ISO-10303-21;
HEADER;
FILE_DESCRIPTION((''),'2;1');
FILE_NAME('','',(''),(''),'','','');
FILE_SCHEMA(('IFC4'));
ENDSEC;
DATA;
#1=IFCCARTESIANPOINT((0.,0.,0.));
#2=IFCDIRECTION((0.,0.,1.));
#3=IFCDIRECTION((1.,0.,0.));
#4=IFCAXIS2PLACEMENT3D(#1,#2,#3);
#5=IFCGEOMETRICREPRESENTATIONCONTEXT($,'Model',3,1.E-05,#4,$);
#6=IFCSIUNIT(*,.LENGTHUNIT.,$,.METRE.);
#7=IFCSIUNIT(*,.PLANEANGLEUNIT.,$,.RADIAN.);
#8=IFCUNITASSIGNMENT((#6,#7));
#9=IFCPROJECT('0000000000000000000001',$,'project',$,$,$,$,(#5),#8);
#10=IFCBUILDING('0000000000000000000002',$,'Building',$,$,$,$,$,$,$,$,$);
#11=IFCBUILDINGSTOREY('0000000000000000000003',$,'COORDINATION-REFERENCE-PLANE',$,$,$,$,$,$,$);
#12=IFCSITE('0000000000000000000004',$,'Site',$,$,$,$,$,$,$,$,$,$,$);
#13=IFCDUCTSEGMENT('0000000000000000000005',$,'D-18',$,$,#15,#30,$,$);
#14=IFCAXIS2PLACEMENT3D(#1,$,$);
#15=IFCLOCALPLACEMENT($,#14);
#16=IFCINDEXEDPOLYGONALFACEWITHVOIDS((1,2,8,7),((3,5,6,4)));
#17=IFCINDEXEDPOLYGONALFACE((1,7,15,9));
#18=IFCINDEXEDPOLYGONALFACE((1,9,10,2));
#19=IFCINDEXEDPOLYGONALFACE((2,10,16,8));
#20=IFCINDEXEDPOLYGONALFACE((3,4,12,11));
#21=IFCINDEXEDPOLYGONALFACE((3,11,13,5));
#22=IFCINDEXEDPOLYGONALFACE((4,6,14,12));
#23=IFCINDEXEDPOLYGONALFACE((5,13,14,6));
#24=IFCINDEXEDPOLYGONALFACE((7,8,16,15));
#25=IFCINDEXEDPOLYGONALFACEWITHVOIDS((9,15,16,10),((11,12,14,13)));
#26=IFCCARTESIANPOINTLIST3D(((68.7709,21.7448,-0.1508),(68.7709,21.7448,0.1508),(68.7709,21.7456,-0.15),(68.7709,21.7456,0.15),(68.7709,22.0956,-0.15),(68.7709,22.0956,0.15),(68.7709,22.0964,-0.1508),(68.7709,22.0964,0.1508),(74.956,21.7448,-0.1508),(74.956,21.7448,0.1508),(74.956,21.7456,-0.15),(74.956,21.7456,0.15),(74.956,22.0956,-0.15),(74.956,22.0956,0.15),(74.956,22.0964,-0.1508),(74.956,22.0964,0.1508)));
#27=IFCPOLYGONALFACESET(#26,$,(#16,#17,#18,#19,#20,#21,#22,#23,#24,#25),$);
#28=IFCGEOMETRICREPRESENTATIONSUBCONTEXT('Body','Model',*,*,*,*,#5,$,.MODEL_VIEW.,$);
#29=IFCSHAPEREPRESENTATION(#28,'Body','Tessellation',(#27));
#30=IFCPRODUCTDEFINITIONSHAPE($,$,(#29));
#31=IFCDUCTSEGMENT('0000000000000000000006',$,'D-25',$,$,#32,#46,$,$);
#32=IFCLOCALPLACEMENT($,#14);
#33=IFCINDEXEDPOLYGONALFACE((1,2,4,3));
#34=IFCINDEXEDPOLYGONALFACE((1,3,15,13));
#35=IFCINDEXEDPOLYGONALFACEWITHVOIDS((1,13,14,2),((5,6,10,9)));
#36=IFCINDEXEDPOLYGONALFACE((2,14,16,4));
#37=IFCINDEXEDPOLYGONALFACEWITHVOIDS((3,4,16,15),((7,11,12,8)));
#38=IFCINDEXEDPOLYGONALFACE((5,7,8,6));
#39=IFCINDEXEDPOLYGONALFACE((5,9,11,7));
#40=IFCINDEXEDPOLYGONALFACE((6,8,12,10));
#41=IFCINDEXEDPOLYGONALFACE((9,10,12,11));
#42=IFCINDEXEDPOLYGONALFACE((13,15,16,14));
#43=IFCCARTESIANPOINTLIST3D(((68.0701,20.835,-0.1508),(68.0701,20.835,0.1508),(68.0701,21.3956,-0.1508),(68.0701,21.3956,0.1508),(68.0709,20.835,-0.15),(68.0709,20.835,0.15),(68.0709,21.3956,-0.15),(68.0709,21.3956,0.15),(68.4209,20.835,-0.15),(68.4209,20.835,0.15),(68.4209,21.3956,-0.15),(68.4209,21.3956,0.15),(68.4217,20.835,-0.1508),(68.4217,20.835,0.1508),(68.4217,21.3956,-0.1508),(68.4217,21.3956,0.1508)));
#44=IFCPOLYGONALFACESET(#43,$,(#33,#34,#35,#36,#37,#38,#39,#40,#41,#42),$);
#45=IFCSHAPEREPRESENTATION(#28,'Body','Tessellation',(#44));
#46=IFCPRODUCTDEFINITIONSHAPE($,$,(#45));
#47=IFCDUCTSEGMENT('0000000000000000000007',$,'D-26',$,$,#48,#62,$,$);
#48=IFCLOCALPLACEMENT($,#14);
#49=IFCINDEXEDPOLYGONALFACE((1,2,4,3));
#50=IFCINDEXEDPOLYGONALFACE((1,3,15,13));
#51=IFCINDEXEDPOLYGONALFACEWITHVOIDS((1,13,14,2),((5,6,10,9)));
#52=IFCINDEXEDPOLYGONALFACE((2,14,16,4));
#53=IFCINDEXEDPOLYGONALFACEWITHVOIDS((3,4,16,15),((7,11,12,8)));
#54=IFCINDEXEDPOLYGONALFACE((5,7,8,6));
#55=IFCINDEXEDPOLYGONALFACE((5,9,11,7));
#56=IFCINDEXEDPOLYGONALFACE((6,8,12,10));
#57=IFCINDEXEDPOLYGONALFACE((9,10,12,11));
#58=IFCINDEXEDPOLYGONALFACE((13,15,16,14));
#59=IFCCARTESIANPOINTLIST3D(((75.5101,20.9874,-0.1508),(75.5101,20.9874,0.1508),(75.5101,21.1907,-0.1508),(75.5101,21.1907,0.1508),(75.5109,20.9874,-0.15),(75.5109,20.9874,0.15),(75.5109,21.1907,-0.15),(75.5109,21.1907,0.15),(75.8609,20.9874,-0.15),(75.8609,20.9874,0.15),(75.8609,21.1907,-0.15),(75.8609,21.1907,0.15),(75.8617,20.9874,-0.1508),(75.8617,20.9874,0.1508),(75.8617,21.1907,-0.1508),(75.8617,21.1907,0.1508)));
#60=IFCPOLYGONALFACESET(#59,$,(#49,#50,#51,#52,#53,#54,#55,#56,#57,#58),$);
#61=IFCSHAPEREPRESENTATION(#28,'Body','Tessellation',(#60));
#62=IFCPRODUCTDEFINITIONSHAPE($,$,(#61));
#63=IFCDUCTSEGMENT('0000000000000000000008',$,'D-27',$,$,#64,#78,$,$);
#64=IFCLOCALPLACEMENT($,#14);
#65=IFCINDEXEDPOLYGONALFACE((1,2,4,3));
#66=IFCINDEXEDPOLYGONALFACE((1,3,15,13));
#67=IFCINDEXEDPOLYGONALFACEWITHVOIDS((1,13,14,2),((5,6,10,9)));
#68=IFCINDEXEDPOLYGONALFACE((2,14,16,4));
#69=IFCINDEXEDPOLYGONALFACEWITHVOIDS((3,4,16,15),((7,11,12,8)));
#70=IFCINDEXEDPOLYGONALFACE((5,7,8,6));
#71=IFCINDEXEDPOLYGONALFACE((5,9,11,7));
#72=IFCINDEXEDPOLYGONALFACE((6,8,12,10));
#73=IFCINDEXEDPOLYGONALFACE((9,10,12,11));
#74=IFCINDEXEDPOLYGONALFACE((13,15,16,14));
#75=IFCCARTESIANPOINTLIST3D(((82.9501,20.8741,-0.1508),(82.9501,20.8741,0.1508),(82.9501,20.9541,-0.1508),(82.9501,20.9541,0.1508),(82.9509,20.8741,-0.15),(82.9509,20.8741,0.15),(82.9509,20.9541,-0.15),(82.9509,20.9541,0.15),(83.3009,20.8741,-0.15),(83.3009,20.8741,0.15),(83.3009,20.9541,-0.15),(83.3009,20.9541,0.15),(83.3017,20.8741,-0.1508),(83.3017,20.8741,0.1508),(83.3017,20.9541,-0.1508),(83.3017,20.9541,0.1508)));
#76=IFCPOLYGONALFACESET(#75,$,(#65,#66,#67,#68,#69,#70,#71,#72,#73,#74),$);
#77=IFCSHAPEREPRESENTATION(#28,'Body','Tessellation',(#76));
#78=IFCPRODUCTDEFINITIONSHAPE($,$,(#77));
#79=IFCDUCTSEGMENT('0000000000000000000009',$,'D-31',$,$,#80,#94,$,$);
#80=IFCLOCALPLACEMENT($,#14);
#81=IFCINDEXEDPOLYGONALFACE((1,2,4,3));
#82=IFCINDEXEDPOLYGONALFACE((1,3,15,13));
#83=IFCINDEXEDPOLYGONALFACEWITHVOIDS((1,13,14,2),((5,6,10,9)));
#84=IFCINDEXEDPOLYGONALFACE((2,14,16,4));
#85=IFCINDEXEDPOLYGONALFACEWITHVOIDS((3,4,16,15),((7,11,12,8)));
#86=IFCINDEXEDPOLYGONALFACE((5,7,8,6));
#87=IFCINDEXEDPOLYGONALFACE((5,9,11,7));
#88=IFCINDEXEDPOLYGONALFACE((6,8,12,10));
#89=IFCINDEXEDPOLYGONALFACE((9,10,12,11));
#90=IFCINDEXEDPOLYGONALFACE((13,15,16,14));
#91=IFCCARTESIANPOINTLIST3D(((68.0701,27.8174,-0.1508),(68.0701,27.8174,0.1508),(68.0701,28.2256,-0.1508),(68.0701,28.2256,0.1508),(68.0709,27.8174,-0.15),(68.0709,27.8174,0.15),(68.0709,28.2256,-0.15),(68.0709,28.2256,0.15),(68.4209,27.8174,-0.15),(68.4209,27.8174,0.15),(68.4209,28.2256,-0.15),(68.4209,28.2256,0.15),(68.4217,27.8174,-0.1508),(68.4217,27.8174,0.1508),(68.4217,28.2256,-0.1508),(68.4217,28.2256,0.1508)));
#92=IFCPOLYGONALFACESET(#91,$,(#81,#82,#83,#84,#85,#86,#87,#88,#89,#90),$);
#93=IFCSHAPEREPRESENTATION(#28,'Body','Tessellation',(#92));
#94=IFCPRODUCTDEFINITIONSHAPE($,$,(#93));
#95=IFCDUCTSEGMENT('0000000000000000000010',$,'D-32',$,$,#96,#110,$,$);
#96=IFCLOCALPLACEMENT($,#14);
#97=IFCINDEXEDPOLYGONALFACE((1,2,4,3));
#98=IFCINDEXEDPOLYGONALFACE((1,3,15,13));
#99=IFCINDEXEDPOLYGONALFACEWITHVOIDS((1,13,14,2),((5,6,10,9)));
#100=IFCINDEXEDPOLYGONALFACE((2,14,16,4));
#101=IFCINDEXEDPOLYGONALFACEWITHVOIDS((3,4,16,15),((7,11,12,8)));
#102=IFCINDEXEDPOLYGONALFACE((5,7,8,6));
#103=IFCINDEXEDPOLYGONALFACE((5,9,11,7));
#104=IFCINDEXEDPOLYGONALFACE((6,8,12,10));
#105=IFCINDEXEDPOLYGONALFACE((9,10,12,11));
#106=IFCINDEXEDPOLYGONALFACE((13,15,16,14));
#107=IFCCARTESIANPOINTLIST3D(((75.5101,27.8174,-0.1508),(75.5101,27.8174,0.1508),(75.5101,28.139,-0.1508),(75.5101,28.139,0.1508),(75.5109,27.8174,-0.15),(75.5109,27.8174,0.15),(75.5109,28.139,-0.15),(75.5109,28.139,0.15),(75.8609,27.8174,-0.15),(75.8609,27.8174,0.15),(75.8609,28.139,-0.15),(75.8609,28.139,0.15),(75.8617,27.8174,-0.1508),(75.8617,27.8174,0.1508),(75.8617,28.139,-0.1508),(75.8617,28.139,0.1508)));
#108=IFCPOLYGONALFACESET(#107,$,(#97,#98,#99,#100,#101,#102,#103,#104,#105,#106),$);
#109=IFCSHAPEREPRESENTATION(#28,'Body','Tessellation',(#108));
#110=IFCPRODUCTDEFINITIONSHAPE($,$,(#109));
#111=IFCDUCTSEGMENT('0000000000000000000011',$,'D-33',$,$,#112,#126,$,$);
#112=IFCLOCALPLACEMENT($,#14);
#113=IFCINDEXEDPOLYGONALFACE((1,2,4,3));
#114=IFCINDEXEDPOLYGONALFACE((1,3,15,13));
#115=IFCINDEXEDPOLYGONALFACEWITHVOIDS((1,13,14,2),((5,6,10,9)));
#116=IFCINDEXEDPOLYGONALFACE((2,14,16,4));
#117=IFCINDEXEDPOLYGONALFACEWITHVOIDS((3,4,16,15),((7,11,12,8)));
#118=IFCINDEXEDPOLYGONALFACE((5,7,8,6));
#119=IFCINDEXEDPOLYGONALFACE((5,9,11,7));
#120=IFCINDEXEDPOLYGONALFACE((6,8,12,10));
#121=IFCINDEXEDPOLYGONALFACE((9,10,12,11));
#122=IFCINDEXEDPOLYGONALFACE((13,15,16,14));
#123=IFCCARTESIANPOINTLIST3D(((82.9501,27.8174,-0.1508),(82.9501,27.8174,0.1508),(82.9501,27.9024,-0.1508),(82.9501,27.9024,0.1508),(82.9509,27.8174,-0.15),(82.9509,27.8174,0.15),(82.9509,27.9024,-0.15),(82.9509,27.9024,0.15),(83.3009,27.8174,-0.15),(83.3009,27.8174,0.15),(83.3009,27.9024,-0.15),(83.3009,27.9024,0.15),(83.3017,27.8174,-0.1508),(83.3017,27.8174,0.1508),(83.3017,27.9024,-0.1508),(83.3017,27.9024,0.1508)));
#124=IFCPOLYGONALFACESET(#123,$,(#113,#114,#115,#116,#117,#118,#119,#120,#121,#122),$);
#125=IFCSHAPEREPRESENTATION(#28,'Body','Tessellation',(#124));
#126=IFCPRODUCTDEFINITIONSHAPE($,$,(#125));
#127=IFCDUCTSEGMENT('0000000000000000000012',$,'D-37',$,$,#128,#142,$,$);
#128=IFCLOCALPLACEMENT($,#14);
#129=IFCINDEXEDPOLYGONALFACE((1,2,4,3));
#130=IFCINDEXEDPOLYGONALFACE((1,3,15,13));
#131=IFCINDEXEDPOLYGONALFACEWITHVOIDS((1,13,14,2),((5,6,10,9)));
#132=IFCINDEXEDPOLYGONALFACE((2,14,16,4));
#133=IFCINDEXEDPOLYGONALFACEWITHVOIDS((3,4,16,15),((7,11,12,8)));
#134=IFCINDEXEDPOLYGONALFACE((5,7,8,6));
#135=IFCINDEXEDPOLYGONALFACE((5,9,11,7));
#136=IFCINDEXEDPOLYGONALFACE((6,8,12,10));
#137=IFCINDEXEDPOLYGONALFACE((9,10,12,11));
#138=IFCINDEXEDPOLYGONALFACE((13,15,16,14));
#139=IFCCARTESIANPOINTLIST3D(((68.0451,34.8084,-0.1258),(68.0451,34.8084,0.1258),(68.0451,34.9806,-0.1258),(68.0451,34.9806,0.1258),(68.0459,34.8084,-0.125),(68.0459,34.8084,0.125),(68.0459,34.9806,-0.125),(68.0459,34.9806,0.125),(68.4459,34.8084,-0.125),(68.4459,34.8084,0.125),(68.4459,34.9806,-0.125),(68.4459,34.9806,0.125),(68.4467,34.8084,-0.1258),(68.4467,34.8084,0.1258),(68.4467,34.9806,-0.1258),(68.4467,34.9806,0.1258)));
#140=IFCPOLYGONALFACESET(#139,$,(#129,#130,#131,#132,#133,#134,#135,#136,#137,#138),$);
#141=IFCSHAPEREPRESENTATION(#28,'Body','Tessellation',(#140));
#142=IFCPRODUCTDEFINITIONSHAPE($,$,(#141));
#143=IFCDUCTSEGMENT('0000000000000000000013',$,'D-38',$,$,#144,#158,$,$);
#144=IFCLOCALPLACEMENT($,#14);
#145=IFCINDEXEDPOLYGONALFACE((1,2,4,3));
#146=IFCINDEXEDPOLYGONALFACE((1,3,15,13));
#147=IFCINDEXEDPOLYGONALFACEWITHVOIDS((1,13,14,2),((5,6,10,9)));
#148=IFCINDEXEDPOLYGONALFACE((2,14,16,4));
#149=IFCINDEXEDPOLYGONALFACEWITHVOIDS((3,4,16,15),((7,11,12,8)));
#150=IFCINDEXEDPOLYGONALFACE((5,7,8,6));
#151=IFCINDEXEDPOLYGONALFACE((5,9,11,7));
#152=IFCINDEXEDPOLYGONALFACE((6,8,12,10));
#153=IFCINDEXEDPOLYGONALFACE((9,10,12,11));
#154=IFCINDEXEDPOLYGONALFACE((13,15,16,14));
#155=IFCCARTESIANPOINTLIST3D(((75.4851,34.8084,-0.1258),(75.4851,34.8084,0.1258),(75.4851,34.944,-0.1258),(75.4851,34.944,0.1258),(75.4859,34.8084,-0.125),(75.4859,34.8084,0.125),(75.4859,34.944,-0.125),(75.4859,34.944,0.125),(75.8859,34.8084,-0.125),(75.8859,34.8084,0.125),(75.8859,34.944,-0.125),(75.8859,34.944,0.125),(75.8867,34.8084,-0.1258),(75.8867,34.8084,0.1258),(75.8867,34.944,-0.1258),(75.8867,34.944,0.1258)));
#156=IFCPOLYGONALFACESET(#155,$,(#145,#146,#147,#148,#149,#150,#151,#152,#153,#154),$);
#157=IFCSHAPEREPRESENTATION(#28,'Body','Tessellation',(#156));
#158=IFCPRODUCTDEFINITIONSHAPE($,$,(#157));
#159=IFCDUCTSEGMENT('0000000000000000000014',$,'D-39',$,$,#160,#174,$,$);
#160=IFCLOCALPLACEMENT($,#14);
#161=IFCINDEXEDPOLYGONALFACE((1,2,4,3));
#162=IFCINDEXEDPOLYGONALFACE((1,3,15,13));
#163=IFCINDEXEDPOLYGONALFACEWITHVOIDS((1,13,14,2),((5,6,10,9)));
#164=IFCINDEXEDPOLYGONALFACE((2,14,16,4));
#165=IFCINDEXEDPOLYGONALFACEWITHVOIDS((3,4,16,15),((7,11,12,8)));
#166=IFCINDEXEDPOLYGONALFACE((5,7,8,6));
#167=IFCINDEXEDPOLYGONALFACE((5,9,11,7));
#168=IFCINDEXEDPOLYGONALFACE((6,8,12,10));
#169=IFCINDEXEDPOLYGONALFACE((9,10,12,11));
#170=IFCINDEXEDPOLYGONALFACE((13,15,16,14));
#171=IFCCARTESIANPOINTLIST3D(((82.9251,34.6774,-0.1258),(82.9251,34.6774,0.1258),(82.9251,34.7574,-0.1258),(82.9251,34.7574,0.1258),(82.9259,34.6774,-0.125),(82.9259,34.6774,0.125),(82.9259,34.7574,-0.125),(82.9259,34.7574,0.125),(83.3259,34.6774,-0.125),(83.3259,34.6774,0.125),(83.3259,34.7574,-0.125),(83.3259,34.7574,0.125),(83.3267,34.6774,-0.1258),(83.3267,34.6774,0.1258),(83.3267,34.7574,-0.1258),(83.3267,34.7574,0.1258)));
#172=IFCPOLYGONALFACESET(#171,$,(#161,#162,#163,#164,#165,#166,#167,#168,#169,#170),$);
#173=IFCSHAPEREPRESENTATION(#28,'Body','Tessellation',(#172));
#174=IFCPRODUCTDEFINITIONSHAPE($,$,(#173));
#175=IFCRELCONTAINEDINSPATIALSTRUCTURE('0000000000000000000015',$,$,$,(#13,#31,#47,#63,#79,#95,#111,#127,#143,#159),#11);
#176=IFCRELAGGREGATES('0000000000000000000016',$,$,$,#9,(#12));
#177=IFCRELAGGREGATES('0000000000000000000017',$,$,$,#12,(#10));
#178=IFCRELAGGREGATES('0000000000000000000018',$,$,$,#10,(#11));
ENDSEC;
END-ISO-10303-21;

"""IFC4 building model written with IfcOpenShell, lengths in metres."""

from ifc_helpers import new_model, si_unit, frame, origin, origin_with_axes, place, context, subcontext, project, spatial, hollow_rectangle, extrude, element, save


model = new_model("IFC4")

# Units and contexts
model_context = context("Model", 3, precision=1e-05, world=origin_with_axes())
body_context = subcontext(model_context, "Body", "Model", "MODEL_VIEW")
ifc_project = project(units=[si_unit("LENGTHUNIT", "METRE"), si_unit("PLANEANGLEUNIT", "RADIAN")], contexts=[model_context])

# Site, building, storey
site = spatial("IfcSite", under=ifc_project, Name="Site")
building = spatial("IfcBuilding", under=site, Name="Building")
storey = spatial("IfcBuildingStorey", under=building, Name="COORDINATION-REFERENCE-PLANE")

# Duct segments
duct_segment_1_placement = place(None, frame((68.7709, 21.9206, 0.0), z_axis=(1.0, 0.0, 0.0), x_axis=(0.0, 1.0, 0.0)))
element("IfcDuctSegment", 1, at=duct_segment_1_placement, inside=storey, Name="D-18", context=body_context, shape_type="SweptSolid", body=[
    extrude(hollow_rectangle(XDim=0.3516, YDim=0.3016, WallThickness=0.0008), origin(), (0.0, 0.0, 1.0), 6.1851),
])
duct_segment_2_placement = place(None, frame((68.2459, 20.835, 0.0), z_axis=(0.0, 1.0, 0.0), x_axis=(1.0, 0.0, 0.0)))
element("IfcDuctSegment", 2, at=duct_segment_2_placement, inside=storey, Name="D-25", context=body_context, shape_type="SweptSolid", body=[
    extrude(hollow_rectangle(XDim=0.3516, YDim=0.3016, WallThickness=0.0008), origin(), (0.0, 0.0, 1.0), 0.5606),
])
duct_segment_3_placement = place(None, frame((75.6859, 20.9874, 0.0), z_axis=(0.0, 1.0, 0.0), x_axis=(1.0, 0.0, 0.0)))
element("IfcDuctSegment", 3, at=duct_segment_3_placement, inside=storey, Name="D-26", context=body_context, shape_type="SweptSolid", body=[
    extrude(hollow_rectangle(XDim=0.3516, YDim=0.3016, WallThickness=0.0008), origin(), (0.0, 0.0, 1.0), 0.2033),
])
duct_segment_4_placement = place(None, frame((83.1259, 20.8741, 0.0), z_axis=(0.0, 1.0, 0.0), x_axis=(1.0, 0.0, 0.0)))
element("IfcDuctSegment", 4, at=duct_segment_4_placement, inside=storey, Name="D-27", context=body_context, shape_type="SweptSolid", body=[
    extrude(hollow_rectangle(XDim=0.3516, YDim=0.3016, WallThickness=0.0008), origin(), (0.0, 0.0, 1.0), 0.08),
])
duct_segment_5_placement = place(None, frame((68.2459, 27.8174, 0.0), z_axis=(0.0, 1.0, 0.0), x_axis=(1.0, 0.0, 0.0)))
element("IfcDuctSegment", 5, at=duct_segment_5_placement, inside=storey, Name="D-31", context=body_context, shape_type="SweptSolid", body=[
    extrude(hollow_rectangle(XDim=0.3516, YDim=0.3016, WallThickness=0.0008), origin(), (0.0, 0.0, 1.0), 0.4082),
])
duct_segment_6_placement = place(None, frame((75.6859, 27.8174, 0.0), z_axis=(0.0, 1.0, 0.0), x_axis=(1.0, 0.0, 0.0)))
element("IfcDuctSegment", 6, at=duct_segment_6_placement, inside=storey, Name="D-32", context=body_context, shape_type="SweptSolid", body=[
    extrude(hollow_rectangle(XDim=0.3516, YDim=0.3016, WallThickness=0.0008), origin(), (0.0, 0.0, 1.0), 0.3216),
])
duct_segment_7_placement = place(None, frame((83.1259, 27.8174, 0.0), z_axis=(0.0, 1.0, 0.0), x_axis=(1.0, 0.0, 0.0)))
element("IfcDuctSegment", 7, at=duct_segment_7_placement, inside=storey, Name="D-33", context=body_context, shape_type="SweptSolid", body=[
    extrude(hollow_rectangle(XDim=0.3516, YDim=0.3016, WallThickness=0.0008), origin(), (0.0, 0.0, 1.0), 0.085),
])
duct_segment_8_placement = place(None, frame((68.2459, 34.8084, 0.0), z_axis=(0.0, 1.0, 0.0), x_axis=(1.0, 0.0, 0.0)))
element("IfcDuctSegment", 8, at=duct_segment_8_placement, inside=storey, Name="D-37", context=body_context, shape_type="SweptSolid", body=[
    extrude(hollow_rectangle(XDim=0.4016, YDim=0.2516, WallThickness=0.0008), origin(), (0.0, 0.0, 1.0), 0.1721),
])
duct_segment_9_placement = place(None, frame((75.6859, 34.8084, 0.0), z_axis=(0.0, 1.0, 0.0), x_axis=(1.0, 0.0, 0.0)))
element("IfcDuctSegment", 9, at=duct_segment_9_placement, inside=storey, Name="D-38", context=body_context, shape_type="SweptSolid", body=[
    extrude(hollow_rectangle(XDim=0.4016, YDim=0.2516, WallThickness=0.0008), origin(), (0.0, 0.0, 1.0), 0.1355),
])
duct_segment_10_placement = place(None, frame((83.1259, 34.6774, 0.0), z_axis=(0.0, 1.0, 0.0), x_axis=(1.0, 0.0, 0.0)))
element("IfcDuctSegment", 10, at=duct_segment_10_placement, inside=storey, Name="D-39", context=body_context, shape_type="SweptSolid", body=[
    extrude(hollow_rectangle(XDim=0.4016, YDim=0.2516, WallThickness=0.0008), origin(), (0.0, 0.0, 1.0), 0.08),
])

save(model, "model.ifc")
